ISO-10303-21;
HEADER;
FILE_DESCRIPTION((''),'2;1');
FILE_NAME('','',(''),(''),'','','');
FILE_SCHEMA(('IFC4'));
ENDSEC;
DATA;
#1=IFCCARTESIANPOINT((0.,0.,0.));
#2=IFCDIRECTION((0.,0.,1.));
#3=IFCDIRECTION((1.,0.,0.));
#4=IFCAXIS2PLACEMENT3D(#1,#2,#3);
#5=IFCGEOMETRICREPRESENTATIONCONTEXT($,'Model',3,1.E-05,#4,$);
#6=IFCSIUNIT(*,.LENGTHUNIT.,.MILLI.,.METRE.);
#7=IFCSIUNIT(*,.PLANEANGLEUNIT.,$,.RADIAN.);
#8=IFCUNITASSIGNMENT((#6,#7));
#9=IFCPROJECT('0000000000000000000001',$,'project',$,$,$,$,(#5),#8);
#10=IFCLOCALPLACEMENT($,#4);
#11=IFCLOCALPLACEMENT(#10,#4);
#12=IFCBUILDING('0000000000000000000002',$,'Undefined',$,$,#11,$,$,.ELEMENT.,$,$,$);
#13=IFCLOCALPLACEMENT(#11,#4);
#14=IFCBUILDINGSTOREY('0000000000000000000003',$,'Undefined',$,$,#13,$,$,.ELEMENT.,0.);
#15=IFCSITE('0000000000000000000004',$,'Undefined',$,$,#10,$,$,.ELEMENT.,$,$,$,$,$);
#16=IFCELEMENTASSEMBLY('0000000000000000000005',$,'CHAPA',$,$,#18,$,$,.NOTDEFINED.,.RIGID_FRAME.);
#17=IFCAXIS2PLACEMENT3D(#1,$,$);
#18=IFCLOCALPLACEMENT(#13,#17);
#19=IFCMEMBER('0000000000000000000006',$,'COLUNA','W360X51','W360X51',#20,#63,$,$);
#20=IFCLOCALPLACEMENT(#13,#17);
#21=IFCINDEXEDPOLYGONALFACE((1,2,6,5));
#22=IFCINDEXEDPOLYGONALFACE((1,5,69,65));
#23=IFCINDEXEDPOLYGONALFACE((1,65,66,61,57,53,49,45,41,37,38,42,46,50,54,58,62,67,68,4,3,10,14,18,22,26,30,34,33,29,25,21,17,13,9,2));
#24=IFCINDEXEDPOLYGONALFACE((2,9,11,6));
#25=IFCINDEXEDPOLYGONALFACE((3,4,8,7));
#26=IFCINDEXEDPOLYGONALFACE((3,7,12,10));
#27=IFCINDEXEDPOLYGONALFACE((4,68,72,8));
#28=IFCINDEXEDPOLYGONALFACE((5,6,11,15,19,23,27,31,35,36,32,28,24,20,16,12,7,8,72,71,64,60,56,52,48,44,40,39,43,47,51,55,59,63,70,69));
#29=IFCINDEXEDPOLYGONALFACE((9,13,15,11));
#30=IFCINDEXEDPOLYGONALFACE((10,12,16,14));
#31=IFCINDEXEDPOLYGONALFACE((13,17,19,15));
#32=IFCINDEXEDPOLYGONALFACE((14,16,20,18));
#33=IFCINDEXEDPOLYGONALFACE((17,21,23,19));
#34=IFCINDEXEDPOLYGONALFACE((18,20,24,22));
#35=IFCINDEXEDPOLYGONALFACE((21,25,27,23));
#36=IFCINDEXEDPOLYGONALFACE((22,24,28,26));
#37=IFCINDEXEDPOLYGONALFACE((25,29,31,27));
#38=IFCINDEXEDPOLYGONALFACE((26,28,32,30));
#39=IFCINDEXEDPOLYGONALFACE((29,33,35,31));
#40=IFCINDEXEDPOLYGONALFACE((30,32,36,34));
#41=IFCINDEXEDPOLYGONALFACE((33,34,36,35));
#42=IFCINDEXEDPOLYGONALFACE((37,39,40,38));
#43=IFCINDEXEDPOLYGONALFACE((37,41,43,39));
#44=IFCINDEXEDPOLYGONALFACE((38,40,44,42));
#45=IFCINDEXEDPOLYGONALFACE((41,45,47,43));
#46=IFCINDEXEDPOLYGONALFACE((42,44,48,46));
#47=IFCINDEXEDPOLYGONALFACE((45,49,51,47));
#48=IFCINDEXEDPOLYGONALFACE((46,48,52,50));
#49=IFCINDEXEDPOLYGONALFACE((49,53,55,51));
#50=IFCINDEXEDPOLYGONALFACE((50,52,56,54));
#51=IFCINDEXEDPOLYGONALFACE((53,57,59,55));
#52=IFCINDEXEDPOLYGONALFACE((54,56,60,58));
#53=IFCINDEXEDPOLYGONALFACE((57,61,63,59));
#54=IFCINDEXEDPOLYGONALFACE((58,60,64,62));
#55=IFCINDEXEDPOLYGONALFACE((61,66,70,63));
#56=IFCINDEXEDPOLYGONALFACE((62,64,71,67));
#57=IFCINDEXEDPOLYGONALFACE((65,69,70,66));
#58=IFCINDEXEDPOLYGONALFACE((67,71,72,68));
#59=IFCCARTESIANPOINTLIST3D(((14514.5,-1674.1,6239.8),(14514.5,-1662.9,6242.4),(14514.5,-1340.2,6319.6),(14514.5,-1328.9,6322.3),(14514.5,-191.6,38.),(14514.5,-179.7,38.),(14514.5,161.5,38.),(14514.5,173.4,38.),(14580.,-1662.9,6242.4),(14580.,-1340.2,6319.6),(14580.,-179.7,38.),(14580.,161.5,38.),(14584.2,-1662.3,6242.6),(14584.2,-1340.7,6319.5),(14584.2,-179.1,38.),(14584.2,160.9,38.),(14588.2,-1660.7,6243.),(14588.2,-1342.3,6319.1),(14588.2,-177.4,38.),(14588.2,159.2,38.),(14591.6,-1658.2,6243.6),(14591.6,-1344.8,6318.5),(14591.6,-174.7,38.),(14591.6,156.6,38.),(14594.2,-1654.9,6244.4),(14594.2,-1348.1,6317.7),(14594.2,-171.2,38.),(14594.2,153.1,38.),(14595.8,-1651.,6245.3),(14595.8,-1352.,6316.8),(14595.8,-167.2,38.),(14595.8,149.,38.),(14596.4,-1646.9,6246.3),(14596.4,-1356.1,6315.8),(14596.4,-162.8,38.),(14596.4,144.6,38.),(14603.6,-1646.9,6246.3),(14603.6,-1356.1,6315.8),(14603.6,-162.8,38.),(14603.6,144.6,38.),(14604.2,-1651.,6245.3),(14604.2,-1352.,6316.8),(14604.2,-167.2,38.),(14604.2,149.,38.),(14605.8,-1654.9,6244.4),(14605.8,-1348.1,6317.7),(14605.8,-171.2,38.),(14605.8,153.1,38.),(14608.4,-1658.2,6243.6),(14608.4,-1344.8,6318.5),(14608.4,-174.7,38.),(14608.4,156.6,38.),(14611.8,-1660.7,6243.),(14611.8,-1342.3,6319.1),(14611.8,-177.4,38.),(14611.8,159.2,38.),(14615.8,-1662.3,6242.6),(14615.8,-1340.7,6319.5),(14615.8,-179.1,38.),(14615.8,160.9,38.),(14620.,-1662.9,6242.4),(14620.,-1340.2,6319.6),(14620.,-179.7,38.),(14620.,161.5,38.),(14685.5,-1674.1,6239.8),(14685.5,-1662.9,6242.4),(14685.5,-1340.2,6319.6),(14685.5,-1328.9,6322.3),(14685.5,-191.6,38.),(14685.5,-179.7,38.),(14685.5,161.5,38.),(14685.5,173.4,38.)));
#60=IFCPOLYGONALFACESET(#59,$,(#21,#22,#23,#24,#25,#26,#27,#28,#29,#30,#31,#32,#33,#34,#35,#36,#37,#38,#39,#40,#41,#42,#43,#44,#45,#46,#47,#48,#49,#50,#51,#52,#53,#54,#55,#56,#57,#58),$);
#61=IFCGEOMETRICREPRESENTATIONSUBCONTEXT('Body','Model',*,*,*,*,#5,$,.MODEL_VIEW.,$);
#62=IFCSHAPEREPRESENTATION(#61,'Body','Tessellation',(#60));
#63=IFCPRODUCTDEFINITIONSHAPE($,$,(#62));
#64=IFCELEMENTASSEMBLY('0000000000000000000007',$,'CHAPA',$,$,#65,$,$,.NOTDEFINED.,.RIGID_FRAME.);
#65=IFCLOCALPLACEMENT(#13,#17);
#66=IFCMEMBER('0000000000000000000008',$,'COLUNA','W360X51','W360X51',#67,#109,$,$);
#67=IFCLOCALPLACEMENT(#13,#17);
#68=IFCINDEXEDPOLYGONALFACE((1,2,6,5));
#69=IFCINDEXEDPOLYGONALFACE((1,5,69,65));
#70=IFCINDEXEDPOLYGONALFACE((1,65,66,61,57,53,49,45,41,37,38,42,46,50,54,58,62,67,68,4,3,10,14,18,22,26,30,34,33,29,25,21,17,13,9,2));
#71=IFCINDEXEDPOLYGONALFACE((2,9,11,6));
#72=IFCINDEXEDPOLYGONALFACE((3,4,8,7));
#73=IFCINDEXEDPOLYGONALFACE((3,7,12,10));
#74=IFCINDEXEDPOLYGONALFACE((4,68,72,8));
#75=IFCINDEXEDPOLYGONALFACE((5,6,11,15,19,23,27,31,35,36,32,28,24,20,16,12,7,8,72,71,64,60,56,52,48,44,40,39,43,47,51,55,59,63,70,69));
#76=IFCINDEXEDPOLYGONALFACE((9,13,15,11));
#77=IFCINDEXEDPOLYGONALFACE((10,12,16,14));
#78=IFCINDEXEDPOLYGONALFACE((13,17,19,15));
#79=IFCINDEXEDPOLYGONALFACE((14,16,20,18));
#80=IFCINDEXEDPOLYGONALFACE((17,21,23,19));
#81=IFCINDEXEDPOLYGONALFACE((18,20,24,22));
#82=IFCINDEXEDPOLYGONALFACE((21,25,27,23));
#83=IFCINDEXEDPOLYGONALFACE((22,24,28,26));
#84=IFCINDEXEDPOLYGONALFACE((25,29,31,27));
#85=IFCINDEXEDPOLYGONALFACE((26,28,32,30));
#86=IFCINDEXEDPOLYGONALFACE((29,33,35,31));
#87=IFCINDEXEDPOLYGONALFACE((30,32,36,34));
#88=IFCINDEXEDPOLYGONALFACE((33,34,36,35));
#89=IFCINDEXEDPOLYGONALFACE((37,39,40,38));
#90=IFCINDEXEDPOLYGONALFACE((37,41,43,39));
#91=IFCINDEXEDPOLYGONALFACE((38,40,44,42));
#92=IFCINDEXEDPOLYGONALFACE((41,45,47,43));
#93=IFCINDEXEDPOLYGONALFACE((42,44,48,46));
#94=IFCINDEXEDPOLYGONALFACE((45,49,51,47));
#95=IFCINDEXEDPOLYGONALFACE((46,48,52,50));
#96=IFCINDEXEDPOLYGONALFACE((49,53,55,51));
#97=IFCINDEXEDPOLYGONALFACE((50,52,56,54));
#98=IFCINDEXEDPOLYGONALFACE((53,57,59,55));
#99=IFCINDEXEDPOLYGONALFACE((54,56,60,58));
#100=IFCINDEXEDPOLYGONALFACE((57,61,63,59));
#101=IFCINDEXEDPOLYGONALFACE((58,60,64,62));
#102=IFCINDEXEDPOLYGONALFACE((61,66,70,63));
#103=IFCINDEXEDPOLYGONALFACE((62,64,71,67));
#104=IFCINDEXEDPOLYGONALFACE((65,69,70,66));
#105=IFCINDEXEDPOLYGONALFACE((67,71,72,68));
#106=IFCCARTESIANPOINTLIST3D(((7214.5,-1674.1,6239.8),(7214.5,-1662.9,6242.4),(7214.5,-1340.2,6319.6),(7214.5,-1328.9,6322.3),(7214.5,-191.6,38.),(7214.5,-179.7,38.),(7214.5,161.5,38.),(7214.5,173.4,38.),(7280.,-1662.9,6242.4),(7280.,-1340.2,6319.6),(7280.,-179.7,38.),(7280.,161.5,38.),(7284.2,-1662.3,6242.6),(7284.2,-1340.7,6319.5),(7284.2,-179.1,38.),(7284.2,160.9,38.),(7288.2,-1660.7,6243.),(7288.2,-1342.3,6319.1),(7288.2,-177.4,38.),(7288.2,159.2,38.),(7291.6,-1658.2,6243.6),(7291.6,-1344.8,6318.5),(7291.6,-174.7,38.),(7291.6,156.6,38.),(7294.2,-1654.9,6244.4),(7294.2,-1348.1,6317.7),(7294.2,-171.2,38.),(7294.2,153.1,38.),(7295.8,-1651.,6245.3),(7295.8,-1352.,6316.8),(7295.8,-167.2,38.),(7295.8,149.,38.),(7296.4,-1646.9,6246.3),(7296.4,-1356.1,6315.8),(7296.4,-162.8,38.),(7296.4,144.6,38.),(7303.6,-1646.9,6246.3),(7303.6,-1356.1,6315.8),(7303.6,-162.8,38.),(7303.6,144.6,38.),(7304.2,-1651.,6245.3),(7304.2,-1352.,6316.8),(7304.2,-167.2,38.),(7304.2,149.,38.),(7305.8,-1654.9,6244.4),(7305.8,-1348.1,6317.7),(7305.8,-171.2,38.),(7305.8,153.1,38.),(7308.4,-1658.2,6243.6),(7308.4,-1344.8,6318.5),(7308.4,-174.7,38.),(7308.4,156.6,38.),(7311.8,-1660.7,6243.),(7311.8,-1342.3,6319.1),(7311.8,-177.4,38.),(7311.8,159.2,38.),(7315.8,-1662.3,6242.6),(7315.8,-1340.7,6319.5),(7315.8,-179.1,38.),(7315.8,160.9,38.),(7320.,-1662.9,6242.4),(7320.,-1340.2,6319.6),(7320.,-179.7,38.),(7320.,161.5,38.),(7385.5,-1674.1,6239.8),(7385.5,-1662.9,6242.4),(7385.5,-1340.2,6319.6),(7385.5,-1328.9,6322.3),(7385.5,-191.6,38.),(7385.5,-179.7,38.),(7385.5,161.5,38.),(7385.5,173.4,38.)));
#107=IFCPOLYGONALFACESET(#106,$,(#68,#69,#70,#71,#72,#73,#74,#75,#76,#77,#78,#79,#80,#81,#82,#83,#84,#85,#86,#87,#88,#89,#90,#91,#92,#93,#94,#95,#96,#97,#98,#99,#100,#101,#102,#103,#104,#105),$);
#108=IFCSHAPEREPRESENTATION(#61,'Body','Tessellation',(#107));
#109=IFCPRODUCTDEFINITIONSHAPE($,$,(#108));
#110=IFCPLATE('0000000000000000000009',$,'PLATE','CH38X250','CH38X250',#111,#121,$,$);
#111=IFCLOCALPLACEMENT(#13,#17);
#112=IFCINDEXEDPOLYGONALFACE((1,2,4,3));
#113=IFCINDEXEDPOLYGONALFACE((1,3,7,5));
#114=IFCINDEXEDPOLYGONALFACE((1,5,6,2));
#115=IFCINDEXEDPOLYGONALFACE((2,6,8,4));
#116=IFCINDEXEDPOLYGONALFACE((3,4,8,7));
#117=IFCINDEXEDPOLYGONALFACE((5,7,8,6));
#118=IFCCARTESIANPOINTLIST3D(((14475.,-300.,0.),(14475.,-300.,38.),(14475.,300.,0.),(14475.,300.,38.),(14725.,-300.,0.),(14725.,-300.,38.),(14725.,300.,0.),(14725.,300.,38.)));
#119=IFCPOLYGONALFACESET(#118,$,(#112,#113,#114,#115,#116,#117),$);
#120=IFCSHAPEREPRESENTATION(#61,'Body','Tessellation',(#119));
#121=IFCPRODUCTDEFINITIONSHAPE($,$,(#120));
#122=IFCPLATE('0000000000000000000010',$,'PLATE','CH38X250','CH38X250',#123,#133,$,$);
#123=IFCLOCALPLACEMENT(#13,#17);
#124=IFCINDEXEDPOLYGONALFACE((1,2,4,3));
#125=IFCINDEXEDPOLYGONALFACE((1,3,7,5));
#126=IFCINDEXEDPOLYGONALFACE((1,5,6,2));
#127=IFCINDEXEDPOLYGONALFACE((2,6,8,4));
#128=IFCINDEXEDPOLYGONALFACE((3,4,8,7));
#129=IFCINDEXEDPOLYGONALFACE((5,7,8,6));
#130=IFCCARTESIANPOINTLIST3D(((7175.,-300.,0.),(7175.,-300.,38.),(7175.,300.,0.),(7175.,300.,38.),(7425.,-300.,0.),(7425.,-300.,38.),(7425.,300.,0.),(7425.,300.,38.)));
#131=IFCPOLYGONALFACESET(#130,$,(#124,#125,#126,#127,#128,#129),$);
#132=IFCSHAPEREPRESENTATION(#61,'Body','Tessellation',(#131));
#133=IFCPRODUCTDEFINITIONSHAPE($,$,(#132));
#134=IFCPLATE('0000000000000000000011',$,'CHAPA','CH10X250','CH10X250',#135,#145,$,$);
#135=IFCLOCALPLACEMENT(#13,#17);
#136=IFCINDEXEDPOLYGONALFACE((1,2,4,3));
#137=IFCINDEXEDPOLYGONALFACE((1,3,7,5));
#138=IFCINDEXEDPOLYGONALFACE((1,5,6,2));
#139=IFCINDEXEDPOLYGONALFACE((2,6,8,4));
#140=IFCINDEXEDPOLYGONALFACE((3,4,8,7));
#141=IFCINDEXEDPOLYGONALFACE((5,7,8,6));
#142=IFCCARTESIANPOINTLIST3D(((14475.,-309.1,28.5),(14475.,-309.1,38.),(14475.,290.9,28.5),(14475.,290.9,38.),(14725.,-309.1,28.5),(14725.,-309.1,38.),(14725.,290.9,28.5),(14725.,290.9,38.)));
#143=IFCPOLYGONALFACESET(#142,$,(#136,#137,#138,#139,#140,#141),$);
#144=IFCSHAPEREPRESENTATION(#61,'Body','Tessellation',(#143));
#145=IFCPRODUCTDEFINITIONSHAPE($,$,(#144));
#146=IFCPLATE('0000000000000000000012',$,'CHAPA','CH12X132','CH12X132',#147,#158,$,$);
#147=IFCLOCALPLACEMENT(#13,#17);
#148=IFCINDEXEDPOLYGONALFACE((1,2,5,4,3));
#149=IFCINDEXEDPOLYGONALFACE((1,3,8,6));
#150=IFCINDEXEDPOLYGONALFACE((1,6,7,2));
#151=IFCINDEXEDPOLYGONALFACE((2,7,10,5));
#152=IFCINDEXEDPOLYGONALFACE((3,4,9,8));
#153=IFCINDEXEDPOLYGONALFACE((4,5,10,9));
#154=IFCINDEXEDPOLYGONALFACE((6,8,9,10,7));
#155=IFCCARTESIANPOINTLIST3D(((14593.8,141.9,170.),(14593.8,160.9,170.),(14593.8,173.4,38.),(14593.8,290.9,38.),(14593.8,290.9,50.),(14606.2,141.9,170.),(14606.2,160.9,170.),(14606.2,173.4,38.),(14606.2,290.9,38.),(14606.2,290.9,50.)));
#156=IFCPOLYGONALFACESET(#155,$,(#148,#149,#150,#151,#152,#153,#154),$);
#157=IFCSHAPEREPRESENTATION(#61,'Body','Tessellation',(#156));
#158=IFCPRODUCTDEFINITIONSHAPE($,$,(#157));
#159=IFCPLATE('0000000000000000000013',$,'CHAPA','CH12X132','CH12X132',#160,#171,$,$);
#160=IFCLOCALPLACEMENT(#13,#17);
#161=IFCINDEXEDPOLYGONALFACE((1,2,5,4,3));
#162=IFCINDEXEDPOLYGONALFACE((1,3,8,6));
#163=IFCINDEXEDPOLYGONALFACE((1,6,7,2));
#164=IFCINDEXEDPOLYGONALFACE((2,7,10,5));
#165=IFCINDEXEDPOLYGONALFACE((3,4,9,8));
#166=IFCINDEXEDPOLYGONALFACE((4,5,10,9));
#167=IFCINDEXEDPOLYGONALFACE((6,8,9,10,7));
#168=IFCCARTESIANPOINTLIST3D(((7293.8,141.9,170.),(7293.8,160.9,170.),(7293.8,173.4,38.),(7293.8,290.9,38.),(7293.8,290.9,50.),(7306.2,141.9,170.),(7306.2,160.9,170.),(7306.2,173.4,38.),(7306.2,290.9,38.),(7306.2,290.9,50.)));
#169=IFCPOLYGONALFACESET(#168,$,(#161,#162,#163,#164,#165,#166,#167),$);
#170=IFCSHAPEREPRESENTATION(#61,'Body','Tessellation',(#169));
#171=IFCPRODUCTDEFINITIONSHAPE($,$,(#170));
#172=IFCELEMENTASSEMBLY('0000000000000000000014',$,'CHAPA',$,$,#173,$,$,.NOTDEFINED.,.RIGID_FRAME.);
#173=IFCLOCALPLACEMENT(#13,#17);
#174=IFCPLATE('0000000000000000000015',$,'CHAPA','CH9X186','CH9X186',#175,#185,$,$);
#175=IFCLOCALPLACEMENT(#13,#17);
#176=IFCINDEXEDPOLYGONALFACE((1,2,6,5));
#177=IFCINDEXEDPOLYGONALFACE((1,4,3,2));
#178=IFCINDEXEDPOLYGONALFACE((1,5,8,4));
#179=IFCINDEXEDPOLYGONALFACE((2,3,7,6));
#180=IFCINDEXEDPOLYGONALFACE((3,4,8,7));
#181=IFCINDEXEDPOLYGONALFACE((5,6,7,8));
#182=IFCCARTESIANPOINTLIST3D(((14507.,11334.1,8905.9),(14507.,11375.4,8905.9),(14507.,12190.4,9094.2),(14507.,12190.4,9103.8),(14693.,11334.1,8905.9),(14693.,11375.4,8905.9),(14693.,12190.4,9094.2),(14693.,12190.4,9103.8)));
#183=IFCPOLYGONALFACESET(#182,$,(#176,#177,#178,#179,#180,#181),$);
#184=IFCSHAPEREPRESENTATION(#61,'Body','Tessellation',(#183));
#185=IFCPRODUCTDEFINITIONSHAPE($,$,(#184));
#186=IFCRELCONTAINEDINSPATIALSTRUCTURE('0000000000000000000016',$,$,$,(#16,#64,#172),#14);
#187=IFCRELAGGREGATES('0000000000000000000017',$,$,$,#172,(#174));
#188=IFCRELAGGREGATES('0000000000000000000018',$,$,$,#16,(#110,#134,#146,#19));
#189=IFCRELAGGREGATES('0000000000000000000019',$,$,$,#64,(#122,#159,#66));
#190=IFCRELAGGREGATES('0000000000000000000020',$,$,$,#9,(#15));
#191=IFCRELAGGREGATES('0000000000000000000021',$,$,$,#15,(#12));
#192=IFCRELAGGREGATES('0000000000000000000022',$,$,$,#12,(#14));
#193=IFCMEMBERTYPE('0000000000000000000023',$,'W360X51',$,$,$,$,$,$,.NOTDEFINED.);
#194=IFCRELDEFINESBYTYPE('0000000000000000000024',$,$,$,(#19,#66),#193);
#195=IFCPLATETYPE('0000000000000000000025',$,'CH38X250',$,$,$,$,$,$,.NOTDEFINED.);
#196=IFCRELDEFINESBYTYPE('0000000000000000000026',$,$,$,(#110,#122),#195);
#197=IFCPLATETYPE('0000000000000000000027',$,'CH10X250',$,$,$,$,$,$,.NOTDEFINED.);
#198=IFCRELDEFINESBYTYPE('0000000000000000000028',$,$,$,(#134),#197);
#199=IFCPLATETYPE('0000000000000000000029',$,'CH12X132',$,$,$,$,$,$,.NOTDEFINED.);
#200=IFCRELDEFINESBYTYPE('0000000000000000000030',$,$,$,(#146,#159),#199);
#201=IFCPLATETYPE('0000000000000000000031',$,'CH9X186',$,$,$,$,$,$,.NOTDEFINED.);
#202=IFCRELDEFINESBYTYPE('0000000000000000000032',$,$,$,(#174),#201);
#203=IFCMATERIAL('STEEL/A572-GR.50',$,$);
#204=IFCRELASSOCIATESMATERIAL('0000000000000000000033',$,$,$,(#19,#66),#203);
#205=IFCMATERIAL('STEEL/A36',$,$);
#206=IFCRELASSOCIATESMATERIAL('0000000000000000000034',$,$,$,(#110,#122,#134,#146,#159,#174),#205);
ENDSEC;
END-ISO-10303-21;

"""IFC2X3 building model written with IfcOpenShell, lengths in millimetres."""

from ifc_helpers import new_model, si_unit, frame, origin_with_axes, origin_2d_with_axis, place, context, subcontext, project, spatial, polyline, i_section, outline, extrude, clip, halfspace, material, type_object, element, aggregate, save


model = new_model("IFC2X3")

# Units and contexts
model_context = context("Model", 3, precision=1e-05, world=origin_with_axes())
body_context = subcontext(model_context, "Body", "Model", "MODEL_VIEW")
ifc_project = project(units=[si_unit("LENGTHUNIT", "METRE", prefix="MILLI"), si_unit("PLANEANGLEUNIT", "RADIAN")], contexts=[model_context])

# Site, building, storey
site_placement = place(None, origin_with_axes())
site = spatial("IfcSite", under=ifc_project, at=site_placement, Name="Undefined", CompositionType="ELEMENT")
building_placement = place(site_placement, origin_with_axes())
building = spatial("IfcBuilding", under=site, at=building_placement, Name="Undefined", CompositionType="ELEMENT")
storey_placement = place(building_placement, origin_with_axes())
storey = spatial("IfcBuildingStorey", under=building, at=storey_placement, Name="Undefined", CompositionType="ELEMENT", Elevation=0.0)

# Element assemblies, members
assembly_1_placement = place(storey_placement, origin_with_axes())
assembly_1 = element("IfcElementAssembly", 1, at=assembly_1_placement, inside=storey, Name="CHAPA", AssemblyPlace="NOTDEFINED", PredefinedType="RIGID_FRAME")
ifc_material_1 = material(Name="STEEL/A572-GR.50")
member_type = type_object("IfcMemberType", Name="W360X51", PredefinedType="NOTDEFINED")
member_1_placement = place(assembly_1_placement, frame((14600.0, 23.3, -97.3), z_axis=(0.0, -0.972595, -0.232504), x_axis=(0.0, -0.232504, 0.972595)))
member_1 = element("IfcMember", 2, at=member_1_placement, type_object=member_type, material=ifc_material_1, Name="COLUNA", Description="W360X51", ObjectType="W360X51", context=body_context, shape_type="Clipping", body=[
    clip(clip(extrude(i_section(OverallWidth=171.0, OverallDepth=355.0, WebThickness=7.2, FlangeThickness=11.6, FilletRadius=16.4, at=origin_2d_with_axis()), frame((6558.0, 0.0, 0.0), z_axis=(-1.0, 0.0, 0.0), x_axis=(0.0, -1.0, 0.0)), (0.0, 0.0, 1.0), 6542.9), halfspace(frame((94.5, 85.5, -186.3), z_axis=(-0.972595, 0.0, 0.232504), x_axis=(0.232504, 0.0, 0.972595)), False)), halfspace(frame((96.6, 0.0, -177.5), z_axis=(0.972595, 0.0, -0.232504), x_axis=(0.0, -1.0, 0.0)), True)),
])
assembly_2_placement = place(storey_placement, origin_with_axes())
assembly_2 = element("IfcElementAssembly", 3, at=assembly_2_placement, inside=storey, Name="CHAPA", AssemblyPlace="NOTDEFINED", PredefinedType="RIGID_FRAME")
member_2_placement = place(assembly_2_placement, frame((7300.0, 23.3, -97.3), z_axis=(0.0, -0.972595, -0.232504), x_axis=(0.0, -0.232504, 0.972595)))
member_2 = element("IfcMember", 4, at=member_2_placement, type_object=member_type, material=ifc_material_1, Name="COLUNA", Description="W360X51", ObjectType="W360X51", context=body_context, shape_type="Clipping", body=[
    clip(clip(extrude(i_section(OverallWidth=171.0, OverallDepth=355.0, WebThickness=7.2, FlangeThickness=11.6, FilletRadius=16.4, at=origin_2d_with_axis()), frame((6558.0, 0.0, 0.0), z_axis=(-1.0, 0.0, 0.0), x_axis=(0.0, -1.0, 0.0)), (0.0, 0.0, 1.0), 6542.9), halfspace(frame((94.5, 85.5, -186.3), z_axis=(-0.972595, 0.0, 0.232504), x_axis=(0.232504, 0.0, 0.972595)), False)), halfspace(frame((96.6, 0.0, -177.5), z_axis=(0.972595, 0.0, -0.232504), x_axis=(0.0, -1.0, 0.0)), True)),
])

# Plates
ifc_material_2 = material(Name="STEEL/A36")
plate_type_1 = type_object("IfcPlateType", Name="CH38X250", PredefinedType="NOTDEFINED")
plate_1_placement = place(assembly_1_placement, frame((14725.0, -300.0, 19.0), z_axis=(0.0, 0.0, 1.0), x_axis=(0.0, 1.0, 0.0)))
plate_1 = element("IfcPlate", 5, at=plate_1_placement, type_object=plate_type_1, material=ifc_material_2, Name="PLATE", Description="CH38X250", ObjectType="CH38X250", context=body_context, shape_type="SweptSolid", body=[
    extrude(outline(polyline([(0.0, 0.0), (600.0, 0.0), (600.0, 250.0), (0.0, 250.0), (0.0, 0.0)])), frame((0.0, 0.0, -19.0), z_axis=(0.0, 0.0, 1.0), x_axis=(1.0, 0.0, 0.0)), (0.0, 0.0, 1.0), 38.0),
])
plate_2_placement = place(assembly_2_placement, frame((7425.0, -300.0, 19.0), z_axis=(0.0, 0.0, 1.0), x_axis=(0.0, 1.0, 0.0)))
plate_2 = element("IfcPlate", 6, at=plate_2_placement, type_object=plate_type_1, material=ifc_material_2, Name="PLATE", Description="CH38X250", ObjectType="CH38X250", context=body_context, shape_type="SweptSolid", body=[
    extrude(outline(polyline([(0.0, 0.0), (600.0, 0.0), (600.0, 250.0), (0.0, 250.0), (0.0, 0.0)])), frame((0.0, 0.0, -19.0), z_axis=(0.0, 0.0, 1.0), x_axis=(1.0, 0.0, 0.0)), (0.0, 0.0, 1.0), 38.0),
])
plate_type_2 = type_object("IfcPlateType", Name="CH10X250", PredefinedType="NOTDEFINED")
plate_3_placement = place(assembly_1_placement, frame((14475.0, -309.1, 33.2), z_axis=(0.0, 0.0, 1.0), x_axis=(1.0, 0.0, 0.0)))
plate_3 = element("IfcPlate", 7, at=plate_3_placement, type_object=plate_type_2, material=ifc_material_2, Name="CHAPA", Description="CH10X250", ObjectType="CH10X250", context=body_context, shape_type="SweptSolid", body=[
    extrude(outline(polyline([(0.0, 0.0), (250.0, 0.0), (250.0, 600.0), (0.0, 600.0), (0.0, 0.0)])), frame((0.0, 0.0, -4.8), z_axis=(0.0, 0.0, 1.0), x_axis=(1.0, 0.0, 0.0)), (0.0, 0.0, 1.0), 9.5),
])
plate_type_3 = type_object("IfcPlateType", Name="CH12X132", PredefinedType="NOTDEFINED")
plate_4_placement = place(assembly_1_placement, frame((14600.0, 173.4, 38.0), z_axis=(1.0, 0.0, 0.0), x_axis=(0.0, 1.0, 0.0)))
plate_4 = element("IfcPlate", 8, at=plate_4_placement, type_object=plate_type_3, material=ifc_material_2, Name="CHAPA", Description="CH12X132", ObjectType="CH12X132", context=body_context, shape_type="SweptSolid", body=[
    extrude(outline(polyline([(0.0, 0.0), (117.5, 0.0), (117.5, 12.0), (-12.5, 132.0), (-31.6, 132.0), (0.0, 0.0)])), frame((0.0, 0.0, -6.2), z_axis=(0.0, 0.0, 1.0), x_axis=(1.0, 0.0, 0.0)), (0.0, 0.0, 1.0), 12.5),
])
plate_5_placement = place(assembly_2_placement, frame((7300.0, 173.4, 38.0), z_axis=(1.0, 0.0, 0.0), x_axis=(0.0, 1.0, 0.0)))
plate_5 = element("IfcPlate", 9, at=plate_5_placement, type_object=plate_type_3, material=ifc_material_2, Name="CHAPA", Description="CH12X132", ObjectType="CH12X132", context=body_context, shape_type="SweptSolid", body=[
    extrude(outline(polyline([(0.0, 0.0), (117.5, 0.0), (117.5, 12.0), (-12.5, 132.0), (-31.6, 132.0), (0.0, 0.0)])), frame((0.0, 0.0, -6.2), z_axis=(0.0, 0.0, 1.0), x_axis=(1.0, 0.0, 0.0)), (0.0, 0.0, 1.0), 12.5),
])

# Element assembly, plate
assembly_3_placement = place(storey_placement, origin_with_axes())
assembly_3 = element("IfcElementAssembly", 10, at=assembly_3_placement, inside=storey, Name="CHAPA", AssemblyPlace="NOTDEFINED", PredefinedType="RIGID_FRAME")
plate_type_4 = type_object("IfcPlateType", Name="CH9X186", PredefinedType="NOTDEFINED")
plate_6_placement = place(assembly_3_placement, frame((14693.0, 12191.4, 9099.3), z_axis=(0.0, -0.225125, 0.97433), x_axis=(-1.0, 0.0, 0.0)))
plate_6 = element("IfcPlate", 11, at=plate_6_placement, type_object=plate_type_4, material=ifc_material_2, Name="CHAPA", Description="CH9X186", ObjectType="CH9X186", context=body_context, shape_type="Clipping", body=[
    clip(clip(extrude(outline(polyline([(0.0, 0.0), (186.0, 0.0), (186.0, 878.9), (0.0, 878.9), (0.0, 0.0)])), frame((0.0, 0.0, -4.7), z_axis=(0.0, 0.0, 1.0), x_axis=(1.0, 0.0, 0.0)), (0.0, 0.0, 1.0), 9.3), halfspace(frame((186.0, -500.0, -314.0), z_axis=(0.0, 0.225128, -0.974329), x_axis=(0.0, 0.974329, 0.225128)), False)), halfspace(frame((0.0, 2.1, -4.6), z_axis=(0.0, -0.97433, -0.225125), x_axis=(0.0, -0.225125, 0.97433)), False)),
])

aggregate(assembly_3, [plate_6])

aggregate(assembly_1, [plate_1, plate_3, plate_4, member_1])
aggregate(assembly_2, [plate_2, plate_5, member_2])

save(model, "model.ifc")
